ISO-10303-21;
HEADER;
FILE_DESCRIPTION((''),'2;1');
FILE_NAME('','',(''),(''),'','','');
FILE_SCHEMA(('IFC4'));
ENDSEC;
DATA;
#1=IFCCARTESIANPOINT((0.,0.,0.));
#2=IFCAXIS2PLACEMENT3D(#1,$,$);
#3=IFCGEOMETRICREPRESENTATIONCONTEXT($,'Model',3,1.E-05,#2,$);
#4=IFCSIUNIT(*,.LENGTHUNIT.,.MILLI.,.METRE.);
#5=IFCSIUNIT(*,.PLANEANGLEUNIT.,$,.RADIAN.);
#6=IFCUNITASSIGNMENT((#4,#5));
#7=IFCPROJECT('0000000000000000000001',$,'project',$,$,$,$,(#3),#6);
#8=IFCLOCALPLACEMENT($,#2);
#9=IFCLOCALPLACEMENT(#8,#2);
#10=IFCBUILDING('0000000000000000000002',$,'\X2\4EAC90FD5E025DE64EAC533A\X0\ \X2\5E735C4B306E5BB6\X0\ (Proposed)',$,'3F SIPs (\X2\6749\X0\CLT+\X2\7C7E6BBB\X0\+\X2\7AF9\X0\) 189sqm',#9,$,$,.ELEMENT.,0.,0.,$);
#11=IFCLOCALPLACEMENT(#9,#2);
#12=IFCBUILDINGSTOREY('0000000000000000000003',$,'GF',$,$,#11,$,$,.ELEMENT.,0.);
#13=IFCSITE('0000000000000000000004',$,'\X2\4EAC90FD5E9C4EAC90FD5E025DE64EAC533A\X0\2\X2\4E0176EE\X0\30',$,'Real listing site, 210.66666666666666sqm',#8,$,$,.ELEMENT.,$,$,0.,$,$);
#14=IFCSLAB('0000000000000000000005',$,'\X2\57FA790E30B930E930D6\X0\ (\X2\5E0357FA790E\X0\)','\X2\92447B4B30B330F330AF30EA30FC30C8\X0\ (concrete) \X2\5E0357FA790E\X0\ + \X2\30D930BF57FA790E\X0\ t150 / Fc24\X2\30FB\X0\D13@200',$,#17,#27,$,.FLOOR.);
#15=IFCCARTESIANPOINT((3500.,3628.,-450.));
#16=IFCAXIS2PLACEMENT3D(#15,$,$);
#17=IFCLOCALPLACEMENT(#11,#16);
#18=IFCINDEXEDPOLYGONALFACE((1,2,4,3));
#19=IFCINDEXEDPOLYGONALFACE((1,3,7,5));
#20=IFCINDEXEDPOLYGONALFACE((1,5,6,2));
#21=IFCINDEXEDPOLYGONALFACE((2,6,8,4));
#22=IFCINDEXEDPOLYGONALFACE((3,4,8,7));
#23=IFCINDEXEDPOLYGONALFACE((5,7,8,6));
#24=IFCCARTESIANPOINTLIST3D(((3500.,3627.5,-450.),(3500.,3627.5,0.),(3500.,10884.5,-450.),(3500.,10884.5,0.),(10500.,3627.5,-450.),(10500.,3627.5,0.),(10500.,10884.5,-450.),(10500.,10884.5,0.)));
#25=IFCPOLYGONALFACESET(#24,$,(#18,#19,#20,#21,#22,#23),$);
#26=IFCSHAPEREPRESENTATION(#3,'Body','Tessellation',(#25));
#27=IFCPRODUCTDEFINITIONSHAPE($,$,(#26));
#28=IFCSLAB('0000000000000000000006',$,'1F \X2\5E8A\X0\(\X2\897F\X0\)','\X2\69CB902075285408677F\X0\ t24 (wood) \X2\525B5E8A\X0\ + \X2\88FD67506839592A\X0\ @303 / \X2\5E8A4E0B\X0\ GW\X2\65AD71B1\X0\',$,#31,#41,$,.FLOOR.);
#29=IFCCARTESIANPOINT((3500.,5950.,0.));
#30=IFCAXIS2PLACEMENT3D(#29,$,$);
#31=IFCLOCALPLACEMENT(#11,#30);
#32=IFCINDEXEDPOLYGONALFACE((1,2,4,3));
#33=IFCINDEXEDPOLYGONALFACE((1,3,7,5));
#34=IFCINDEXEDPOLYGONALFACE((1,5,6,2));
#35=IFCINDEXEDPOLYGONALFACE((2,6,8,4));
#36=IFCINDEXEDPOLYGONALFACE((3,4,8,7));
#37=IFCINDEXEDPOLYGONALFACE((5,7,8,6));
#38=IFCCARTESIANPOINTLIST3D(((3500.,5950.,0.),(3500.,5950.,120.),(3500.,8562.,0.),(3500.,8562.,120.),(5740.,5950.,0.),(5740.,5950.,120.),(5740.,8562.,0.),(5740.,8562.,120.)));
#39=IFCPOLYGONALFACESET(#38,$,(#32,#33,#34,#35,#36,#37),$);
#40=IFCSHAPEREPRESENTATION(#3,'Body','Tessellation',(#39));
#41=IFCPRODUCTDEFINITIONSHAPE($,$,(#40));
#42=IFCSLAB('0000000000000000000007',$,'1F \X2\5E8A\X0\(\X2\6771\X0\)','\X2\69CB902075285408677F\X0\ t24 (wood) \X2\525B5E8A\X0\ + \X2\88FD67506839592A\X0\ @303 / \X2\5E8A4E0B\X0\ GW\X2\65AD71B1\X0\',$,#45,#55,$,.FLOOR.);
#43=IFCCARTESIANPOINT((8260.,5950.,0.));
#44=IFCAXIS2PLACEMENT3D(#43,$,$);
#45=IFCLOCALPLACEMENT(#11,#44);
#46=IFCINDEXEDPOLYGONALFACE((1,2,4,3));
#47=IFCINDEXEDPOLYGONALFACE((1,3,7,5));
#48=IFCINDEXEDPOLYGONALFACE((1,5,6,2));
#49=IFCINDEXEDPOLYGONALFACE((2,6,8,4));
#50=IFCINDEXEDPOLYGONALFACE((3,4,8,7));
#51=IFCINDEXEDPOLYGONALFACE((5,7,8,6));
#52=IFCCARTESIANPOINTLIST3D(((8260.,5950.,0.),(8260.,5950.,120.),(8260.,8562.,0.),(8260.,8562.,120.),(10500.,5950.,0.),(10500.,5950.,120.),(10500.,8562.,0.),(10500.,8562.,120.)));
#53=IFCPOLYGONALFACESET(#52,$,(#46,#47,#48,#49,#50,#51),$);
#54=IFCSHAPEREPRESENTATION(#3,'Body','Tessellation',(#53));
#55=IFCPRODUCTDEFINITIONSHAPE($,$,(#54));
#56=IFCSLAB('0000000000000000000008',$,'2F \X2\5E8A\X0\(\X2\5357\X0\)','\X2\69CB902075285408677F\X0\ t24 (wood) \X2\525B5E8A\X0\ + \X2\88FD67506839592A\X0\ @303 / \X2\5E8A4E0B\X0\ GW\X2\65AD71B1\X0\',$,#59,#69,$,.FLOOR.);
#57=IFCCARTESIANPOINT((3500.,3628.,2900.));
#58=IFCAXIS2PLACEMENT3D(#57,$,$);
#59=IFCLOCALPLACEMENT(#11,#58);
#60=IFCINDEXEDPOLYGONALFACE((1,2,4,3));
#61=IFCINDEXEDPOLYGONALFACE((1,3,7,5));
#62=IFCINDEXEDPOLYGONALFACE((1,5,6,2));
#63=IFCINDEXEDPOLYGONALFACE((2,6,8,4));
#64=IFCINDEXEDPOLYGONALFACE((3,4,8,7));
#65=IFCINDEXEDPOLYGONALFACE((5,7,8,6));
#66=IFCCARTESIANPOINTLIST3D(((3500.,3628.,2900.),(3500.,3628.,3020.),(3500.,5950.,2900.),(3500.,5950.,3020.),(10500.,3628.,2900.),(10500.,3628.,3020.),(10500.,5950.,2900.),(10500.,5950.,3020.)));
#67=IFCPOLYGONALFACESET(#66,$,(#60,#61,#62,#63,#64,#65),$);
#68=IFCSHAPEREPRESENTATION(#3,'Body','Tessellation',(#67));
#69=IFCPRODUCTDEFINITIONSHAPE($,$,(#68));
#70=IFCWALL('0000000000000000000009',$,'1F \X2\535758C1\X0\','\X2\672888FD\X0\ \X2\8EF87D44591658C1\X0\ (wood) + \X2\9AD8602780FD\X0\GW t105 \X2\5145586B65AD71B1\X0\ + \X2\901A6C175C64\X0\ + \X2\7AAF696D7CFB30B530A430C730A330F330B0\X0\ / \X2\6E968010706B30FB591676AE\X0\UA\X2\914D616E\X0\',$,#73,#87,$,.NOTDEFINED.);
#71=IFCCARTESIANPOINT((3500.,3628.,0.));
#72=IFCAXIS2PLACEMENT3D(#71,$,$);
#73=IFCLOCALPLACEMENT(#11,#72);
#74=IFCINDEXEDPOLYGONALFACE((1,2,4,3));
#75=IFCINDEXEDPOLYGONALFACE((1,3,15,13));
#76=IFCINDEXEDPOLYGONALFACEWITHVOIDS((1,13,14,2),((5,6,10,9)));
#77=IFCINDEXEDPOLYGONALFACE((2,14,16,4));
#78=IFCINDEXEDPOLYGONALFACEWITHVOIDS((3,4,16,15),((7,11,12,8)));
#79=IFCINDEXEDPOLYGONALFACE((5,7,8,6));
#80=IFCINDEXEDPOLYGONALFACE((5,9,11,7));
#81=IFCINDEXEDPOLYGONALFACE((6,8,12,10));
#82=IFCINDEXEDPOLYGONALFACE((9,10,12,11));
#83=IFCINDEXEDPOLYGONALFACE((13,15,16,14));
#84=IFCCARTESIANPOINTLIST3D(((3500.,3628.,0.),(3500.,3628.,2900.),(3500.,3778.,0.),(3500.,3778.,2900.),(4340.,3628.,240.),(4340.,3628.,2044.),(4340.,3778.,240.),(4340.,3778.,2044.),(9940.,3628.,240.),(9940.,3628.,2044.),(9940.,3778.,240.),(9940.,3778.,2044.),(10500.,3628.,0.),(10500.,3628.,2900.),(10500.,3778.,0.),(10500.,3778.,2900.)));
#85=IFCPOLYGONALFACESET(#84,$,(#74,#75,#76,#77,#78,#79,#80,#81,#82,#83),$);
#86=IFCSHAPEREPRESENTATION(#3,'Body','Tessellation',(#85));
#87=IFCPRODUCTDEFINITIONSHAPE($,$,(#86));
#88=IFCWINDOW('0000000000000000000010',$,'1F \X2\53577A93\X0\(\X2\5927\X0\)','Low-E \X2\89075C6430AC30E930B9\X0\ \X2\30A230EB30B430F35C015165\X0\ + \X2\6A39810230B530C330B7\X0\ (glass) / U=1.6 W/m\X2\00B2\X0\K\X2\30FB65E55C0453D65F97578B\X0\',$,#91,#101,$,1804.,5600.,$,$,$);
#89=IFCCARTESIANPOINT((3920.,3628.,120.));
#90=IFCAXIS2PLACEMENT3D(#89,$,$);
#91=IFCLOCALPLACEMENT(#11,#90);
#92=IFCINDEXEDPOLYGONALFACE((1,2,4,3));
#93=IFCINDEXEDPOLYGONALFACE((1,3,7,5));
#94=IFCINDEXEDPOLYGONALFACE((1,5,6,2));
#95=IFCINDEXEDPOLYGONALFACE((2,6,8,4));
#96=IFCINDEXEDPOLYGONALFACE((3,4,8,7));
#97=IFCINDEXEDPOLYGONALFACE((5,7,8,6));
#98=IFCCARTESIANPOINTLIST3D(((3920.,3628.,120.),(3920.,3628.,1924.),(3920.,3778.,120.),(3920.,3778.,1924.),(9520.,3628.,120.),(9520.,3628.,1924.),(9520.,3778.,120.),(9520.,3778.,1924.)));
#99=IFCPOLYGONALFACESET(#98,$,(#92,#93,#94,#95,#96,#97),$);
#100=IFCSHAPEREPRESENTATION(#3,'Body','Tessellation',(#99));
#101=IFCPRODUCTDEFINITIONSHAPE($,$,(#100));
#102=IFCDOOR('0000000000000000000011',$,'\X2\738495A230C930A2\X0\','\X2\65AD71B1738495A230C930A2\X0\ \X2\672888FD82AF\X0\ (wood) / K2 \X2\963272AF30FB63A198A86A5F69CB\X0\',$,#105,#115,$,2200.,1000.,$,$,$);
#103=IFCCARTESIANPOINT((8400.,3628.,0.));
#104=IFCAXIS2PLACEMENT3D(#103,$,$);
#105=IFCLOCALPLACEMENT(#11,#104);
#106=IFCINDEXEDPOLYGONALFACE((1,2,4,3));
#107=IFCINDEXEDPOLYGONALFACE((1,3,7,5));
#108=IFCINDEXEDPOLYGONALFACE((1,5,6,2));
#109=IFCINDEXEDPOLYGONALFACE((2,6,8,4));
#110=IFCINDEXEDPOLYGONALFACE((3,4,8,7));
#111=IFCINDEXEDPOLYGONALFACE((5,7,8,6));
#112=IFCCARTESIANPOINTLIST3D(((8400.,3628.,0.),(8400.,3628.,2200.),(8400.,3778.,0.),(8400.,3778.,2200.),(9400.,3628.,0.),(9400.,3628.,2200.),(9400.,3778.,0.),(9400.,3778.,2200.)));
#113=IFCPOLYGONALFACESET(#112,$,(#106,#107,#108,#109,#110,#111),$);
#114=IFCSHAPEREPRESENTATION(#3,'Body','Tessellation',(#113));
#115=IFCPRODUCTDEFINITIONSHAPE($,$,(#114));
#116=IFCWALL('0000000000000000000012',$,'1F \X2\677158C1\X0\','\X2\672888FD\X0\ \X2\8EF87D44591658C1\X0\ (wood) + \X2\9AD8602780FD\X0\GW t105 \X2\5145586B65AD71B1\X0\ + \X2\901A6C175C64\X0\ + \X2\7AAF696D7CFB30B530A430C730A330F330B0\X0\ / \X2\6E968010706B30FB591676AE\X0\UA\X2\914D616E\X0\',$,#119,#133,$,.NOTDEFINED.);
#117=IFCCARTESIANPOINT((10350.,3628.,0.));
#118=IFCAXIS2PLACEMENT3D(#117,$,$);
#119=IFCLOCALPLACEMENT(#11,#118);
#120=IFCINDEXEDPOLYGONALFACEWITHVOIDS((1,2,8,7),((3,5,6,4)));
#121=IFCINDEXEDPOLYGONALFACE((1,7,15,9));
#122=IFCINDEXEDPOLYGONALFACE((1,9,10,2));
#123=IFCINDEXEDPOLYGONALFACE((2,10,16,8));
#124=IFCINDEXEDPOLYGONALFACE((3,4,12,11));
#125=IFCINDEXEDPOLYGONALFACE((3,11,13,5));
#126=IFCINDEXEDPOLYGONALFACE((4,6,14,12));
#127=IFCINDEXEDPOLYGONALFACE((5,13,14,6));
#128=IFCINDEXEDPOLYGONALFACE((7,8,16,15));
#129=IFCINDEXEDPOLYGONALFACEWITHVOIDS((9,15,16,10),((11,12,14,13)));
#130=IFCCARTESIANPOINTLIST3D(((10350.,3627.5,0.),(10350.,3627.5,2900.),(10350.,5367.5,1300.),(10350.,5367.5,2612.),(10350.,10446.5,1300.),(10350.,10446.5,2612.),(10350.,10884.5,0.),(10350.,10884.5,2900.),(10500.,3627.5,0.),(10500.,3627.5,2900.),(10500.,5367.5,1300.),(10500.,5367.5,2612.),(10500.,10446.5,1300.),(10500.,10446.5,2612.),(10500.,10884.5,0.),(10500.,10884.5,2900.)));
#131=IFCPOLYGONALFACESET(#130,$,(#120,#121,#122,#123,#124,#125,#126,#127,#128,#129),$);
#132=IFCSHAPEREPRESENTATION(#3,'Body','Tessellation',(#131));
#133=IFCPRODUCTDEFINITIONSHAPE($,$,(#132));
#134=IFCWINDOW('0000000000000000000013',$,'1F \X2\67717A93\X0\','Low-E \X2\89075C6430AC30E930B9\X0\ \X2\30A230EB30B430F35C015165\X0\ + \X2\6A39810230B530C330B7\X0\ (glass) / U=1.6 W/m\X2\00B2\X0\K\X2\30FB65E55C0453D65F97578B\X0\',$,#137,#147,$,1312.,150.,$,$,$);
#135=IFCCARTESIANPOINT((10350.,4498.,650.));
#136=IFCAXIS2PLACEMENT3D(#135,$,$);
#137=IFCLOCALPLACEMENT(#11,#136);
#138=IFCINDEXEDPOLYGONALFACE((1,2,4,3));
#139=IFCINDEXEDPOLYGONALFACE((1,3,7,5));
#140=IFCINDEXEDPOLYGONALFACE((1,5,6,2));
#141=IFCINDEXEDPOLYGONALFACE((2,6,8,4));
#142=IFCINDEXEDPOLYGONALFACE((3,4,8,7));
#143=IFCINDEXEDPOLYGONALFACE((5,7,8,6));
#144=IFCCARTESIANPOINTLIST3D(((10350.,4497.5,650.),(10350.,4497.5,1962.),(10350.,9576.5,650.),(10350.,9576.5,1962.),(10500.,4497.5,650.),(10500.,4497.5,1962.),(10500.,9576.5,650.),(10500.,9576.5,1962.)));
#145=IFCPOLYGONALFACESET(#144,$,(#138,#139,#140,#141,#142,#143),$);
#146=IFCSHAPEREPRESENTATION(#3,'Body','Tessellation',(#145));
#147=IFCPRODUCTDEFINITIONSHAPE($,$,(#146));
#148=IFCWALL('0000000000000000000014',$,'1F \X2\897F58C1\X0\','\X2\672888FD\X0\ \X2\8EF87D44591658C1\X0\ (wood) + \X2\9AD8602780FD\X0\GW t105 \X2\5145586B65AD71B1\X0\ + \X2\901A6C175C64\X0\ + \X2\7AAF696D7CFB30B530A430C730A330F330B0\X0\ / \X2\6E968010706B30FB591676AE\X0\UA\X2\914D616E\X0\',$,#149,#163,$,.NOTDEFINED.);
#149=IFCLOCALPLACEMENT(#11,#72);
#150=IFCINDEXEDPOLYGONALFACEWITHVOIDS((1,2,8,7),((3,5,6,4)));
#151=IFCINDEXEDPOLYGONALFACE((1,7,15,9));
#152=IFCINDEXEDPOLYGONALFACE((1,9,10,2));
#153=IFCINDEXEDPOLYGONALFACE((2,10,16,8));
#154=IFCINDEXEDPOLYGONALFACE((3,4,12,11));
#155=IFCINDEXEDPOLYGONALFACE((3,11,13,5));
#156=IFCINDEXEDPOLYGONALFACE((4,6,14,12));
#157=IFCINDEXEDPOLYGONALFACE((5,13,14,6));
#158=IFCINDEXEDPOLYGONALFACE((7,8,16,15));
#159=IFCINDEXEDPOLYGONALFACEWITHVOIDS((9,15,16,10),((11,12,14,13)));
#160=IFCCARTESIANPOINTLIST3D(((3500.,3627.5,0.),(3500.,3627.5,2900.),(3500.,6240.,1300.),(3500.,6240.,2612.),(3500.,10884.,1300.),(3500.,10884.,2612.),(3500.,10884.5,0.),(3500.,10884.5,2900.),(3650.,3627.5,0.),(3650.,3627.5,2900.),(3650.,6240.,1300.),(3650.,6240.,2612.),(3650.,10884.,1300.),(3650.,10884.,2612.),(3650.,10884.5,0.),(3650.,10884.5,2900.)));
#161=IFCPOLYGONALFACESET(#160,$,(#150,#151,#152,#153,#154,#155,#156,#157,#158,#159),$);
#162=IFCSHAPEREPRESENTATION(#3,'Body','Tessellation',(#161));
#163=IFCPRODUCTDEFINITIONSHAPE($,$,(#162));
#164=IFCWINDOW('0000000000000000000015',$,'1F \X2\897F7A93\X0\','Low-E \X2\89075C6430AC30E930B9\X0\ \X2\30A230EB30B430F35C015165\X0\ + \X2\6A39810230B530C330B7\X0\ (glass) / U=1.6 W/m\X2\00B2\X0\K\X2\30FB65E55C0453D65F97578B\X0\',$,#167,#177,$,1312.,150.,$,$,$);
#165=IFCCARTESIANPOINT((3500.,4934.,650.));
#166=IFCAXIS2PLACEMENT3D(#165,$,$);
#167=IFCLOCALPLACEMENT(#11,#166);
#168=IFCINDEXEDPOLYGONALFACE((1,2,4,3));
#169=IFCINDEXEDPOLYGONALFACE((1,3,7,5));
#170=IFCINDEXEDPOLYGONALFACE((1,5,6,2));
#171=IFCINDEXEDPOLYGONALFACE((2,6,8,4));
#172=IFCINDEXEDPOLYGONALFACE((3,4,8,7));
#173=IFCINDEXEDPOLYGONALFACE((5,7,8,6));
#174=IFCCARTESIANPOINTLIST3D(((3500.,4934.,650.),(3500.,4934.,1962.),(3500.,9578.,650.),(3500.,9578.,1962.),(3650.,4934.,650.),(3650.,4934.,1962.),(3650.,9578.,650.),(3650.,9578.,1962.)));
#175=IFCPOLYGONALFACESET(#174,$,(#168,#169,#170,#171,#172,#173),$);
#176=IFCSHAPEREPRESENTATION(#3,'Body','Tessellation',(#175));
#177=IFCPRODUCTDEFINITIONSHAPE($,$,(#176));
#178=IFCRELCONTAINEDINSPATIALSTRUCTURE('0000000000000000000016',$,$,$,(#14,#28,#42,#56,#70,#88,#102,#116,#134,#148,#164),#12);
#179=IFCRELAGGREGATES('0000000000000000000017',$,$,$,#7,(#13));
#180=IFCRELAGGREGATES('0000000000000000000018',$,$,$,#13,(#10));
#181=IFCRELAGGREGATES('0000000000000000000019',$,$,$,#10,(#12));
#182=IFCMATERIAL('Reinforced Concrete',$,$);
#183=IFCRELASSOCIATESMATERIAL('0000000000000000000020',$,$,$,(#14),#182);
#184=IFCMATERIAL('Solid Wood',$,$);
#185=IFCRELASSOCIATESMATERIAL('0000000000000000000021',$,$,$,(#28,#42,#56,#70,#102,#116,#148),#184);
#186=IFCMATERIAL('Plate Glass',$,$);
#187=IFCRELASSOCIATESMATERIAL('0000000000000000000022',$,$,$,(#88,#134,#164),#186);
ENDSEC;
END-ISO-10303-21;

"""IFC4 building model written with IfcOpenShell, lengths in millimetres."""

from ifc_helpers import new_model, si_unit, frame, frame_2d, origin, place, context, project, spatial, rectangle, extrude, material, element, fill, save


model = new_model("IFC4")

# Units and contexts
model_context = context("Model", 3, precision=1e-05, world=origin())
ifc_project = project(units=[si_unit("LENGTHUNIT", "METRE", prefix="MILLI"), si_unit("PLANEANGLEUNIT", "RADIAN")], contexts=[model_context])

# Site, building, storey
site_placement = place(None, origin())
site = spatial("IfcSite", under=ifc_project, at=site_placement, Name="京都府京都市左京区2丁目30", ObjectType="Real listing site, 210.66666666666666sqm", CompositionType="ELEMENT", RefElevation=0.0)
building_placement = place(site_placement, origin())
building = spatial("IfcBuilding", under=site, at=building_placement, Name="京都市左京区 平屋の家 (Proposed)", ObjectType="3F SIPs (杉CLT+籾殻+竹) 189sqm", CompositionType="ELEMENT", ElevationOfRefHeight=0.0, ElevationOfTerrain=0.0)
storey_placement = place(building_placement, origin())
storey = spatial("IfcBuildingStorey", under=building, at=storey_placement, Name="GF", CompositionType="ELEMENT", Elevation=0.0)

# Slabs
ifc_material_1 = material(Name="Reinforced Concrete")
slab_1_placement = place(storey_placement, frame((3500.0, 3628.0, -450.0)))
element("IfcSlab", 1, at=slab_1_placement, inside=storey, material=ifc_material_1, Name="基礎スラブ (布基礎)", Description="鉄筋コンクリート (concrete) 布基礎 + ベタ基礎 t150 / Fc24・D13@200", PredefinedType="FLOOR", context=model_context, shape_type="SweptSolid", body=[
    extrude(rectangle(XDim=7000.0, YDim=7257.0, at=frame_2d((3500.0, 3628.0))), frame((3500.0, 3628.0, -450.0)), (0.0, 0.0, 1.0), 450.0),
])
ifc_material_2 = material(Name="Solid Wood")
slab_2_placement = place(storey_placement, frame((3500.0, 5950.0, 0.0)))
element("IfcSlab", 2, at=slab_2_placement, inside=storey, material=ifc_material_2, Name="1F 床(西)", Description="構造用合板 t24 (wood) 剛床 + 製材根太 @303 / 床下 GW断熱", PredefinedType="FLOOR", context=model_context, shape_type="SweptSolid", body=[
    extrude(rectangle(XDim=2240.0, YDim=2612.0, at=frame_2d((1120.0, 1306.0))), frame((3500.0, 5950.0, 0.0)), (0.0, 0.0, 1.0), 120.0),
])
slab_3_placement = place(storey_placement, frame((8260.0, 5950.0, 0.0)))
element("IfcSlab", 3, at=slab_3_placement, inside=storey, material=ifc_material_2, Name="1F 床(東)", Description="構造用合板 t24 (wood) 剛床 + 製材根太 @303 / 床下 GW断熱", PredefinedType="FLOOR", context=model_context, shape_type="SweptSolid", body=[
    extrude(rectangle(XDim=2240.0, YDim=2612.0, at=frame_2d((1120.0, 1306.0))), frame((8260.0, 5950.0, 0.0)), (0.0, 0.0, 1.0), 120.0),
])
slab_4_placement = place(storey_placement, frame((3500.0, 3628.0, 2900.0)))
element("IfcSlab", 4, at=slab_4_placement, inside=storey, material=ifc_material_2, Name="2F 床(南)", Description="構造用合板 t24 (wood) 剛床 + 製材根太 @303 / 床下 GW断熱", PredefinedType="FLOOR", context=model_context, shape_type="SweptSolid", body=[
    extrude(rectangle(XDim=7000.0, YDim=2322.0, at=frame_2d((3500.0, 1161.0))), frame((3500.0, 3628.0, 2900.0)), (0.0, 0.0, 1.0), 120.0),
])

# Wall, openings, window, door
wall_1_placement = place(storey_placement, frame((3500.0, 3628.0, 0.0)))
wall_1 = element("IfcWall", 5, at=wall_1_placement, inside=storey, material=ifc_material_2, Name="1F 南壁", Description="木製 軸組外壁 (wood) + 高性能GW t105 充填断熱 + 通気層 + 窯業系サイディング / 準耐火・外皮UA配慮", PredefinedType="NOTDEFINED", context=model_context, shape_type="SweptSolid", body=[
    extrude(rectangle(XDim=7000.0, YDim=150.0, at=frame_2d((3500.0, 75.0))), frame((3500.0, 3628.0, 0.0)), (0.0, 0.0, 1.0), 2900.0),
])
opening_1_placement = place(storey_placement, frame((3920.0, 3628.0, 120.0)))
opening_1 = element("IfcOpeningElement", 6, at=opening_1_placement, cuts=wall_1, PredefinedType="NOTDEFINED", context=model_context, shape_type="SweptSolid", body=[
    extrude(rectangle(XDim=5600.0, YDim=150.0, at=frame_2d((2800.0, 75.0))), frame((3920.0, 3628.0, 120.0)), (0.0, 0.0, 1.0), 1804.0),
])
opening_2_placement = place(storey_placement, frame((8400.0, 3628.0, 0.0)))
opening_2 = element("IfcOpeningElement", 7, at=opening_2_placement, cuts=wall_1, PredefinedType="NOTDEFINED", context=model_context, shape_type="SweptSolid", body=[
    extrude(rectangle(XDim=1000.0, YDim=150.0, at=frame_2d((500.0, 75.0))), frame((8400.0, 3628.0, 0.0)), (0.0, 0.0, 1.0), 2200.0),
])
ifc_material_3 = material(Name="Plate Glass")
window_1_placement = place(storey_placement, frame((3920.0, 3628.0, 120.0)))
window_1 = element("IfcWindow", 8, at=window_1_placement, inside=storey, material=ifc_material_3, Name="1F 南窓(大)", Description="Low-E 複層ガラス アルゴン封入 + 樹脂サッシ (glass) / U=1.6 W/m²K・日射取得型", OverallHeight=1804.0, OverallWidth=5600.0, context=model_context, shape_type="SweptSolid", body=[
    extrude(rectangle(XDim=5600.0, YDim=150.0, at=frame_2d((2800.0, 75.0))), frame((3920.0, 3628.0, 120.0)), (0.0, 0.0, 1.0), 1804.0),
])
fill(opening_1, window_1)
door_placement = place(storey_placement, frame((8400.0, 3628.0, 0.0)))
door = element("IfcDoor", 9, at=door_placement, inside=storey, material=ifc_material_2, Name="玄関ドア", Description="断熱玄関ドア 木製芯 (wood) / K2 防犯・採風機構", OverallHeight=2200.0, OverallWidth=1000.0, context=model_context, shape_type="SweptSolid", body=[
    extrude(rectangle(XDim=1000.0, YDim=150.0, at=frame_2d((500.0, 75.0))), frame((8400.0, 3628.0, 0.0)), (0.0, 0.0, 1.0), 2200.0),
])
fill(opening_2, door)

# Walls, openings, windows
wall_2_placement = place(storey_placement, frame((10350.0, 3628.0, 0.0)))
wall_2 = element("IfcWall", 10, at=wall_2_placement, inside=storey, material=ifc_material_2, Name="1F 東壁", Description="木製 軸組外壁 (wood) + 高性能GW t105 充填断熱 + 通気層 + 窯業系サイディング / 準耐火・外皮UA配慮", PredefinedType="NOTDEFINED", context=model_context, shape_type="SweptSolid", body=[
    extrude(rectangle(XDim=150.0, YDim=7257.0, at=frame_2d((75.0, 3628.0))), frame((10350.0, 3628.0, 0.0)), (0.0, 0.0, 1.0), 2900.0),
])
opening_3_placement = place(storey_placement, frame((10350.0, 4498.0, 650.0)))
opening_3 = element("IfcOpeningElement", 11, at=opening_3_placement, cuts=wall_2, PredefinedType="NOTDEFINED", context=model_context, shape_type="SweptSolid", body=[
    extrude(rectangle(XDim=150.0, YDim=5079.0, at=frame_2d((75.0, 2539.0))), frame((10350.0, 4498.0, 650.0)), (0.0, 0.0, 1.0), 1312.0),
])
window_2_placement = place(storey_placement, frame((10350.0, 4498.0, 650.0)))
window_2 = element("IfcWindow", 12, at=window_2_placement, inside=storey, material=ifc_material_3, Name="1F 東窓", Description="Low-E 複層ガラス アルゴン封入 + 樹脂サッシ (glass) / U=1.6 W/m²K・日射取得型", OverallHeight=1312.0, OverallWidth=150.0, context=model_context, shape_type="SweptSolid", body=[
    extrude(rectangle(XDim=150.0, YDim=5079.0, at=frame_2d((75.0, 2539.0))), frame((10350.0, 4498.0, 650.0)), (0.0, 0.0, 1.0), 1312.0),
])
fill(opening_3, window_2)
wall_3_placement = place(storey_placement, frame((3500.0, 3628.0, 0.0)))
wall_3 = element("IfcWall", 13, at=wall_3_placement, inside=storey, material=ifc_material_2, Name="1F 西壁", Description="木製 軸組外壁 (wood) + 高性能GW t105 充填断熱 + 通気層 + 窯業系サイディング / 準耐火・外皮UA配慮", PredefinedType="NOTDEFINED", context=model_context, shape_type="SweptSolid", body=[
    extrude(rectangle(XDim=150.0, YDim=7257.0, at=frame_2d((75.0, 3628.0))), frame((3500.0, 3628.0, 0.0)), (0.0, 0.0, 1.0), 2900.0),
])
opening_4_placement = place(storey_placement, frame((3500.0, 4934.0, 650.0)))
opening_4 = element("IfcOpeningElement", 14, at=opening_4_placement, cuts=wall_3, PredefinedType="NOTDEFINED", context=model_context, shape_type="SweptSolid", body=[
    extrude(rectangle(XDim=150.0, YDim=4644.0, at=frame_2d((75.0, 2322.0))), frame((3500.0, 4934.0, 650.0)), (0.0, 0.0, 1.0), 1312.0),
])
window_3_placement = place(storey_placement, frame((3500.0, 4934.0, 650.0)))
window_3 = element("IfcWindow", 15, at=window_3_placement, inside=storey, material=ifc_material_3, Name="1F 西窓", Description="Low-E 複層ガラス アルゴン封入 + 樹脂サッシ (glass) / U=1.6 W/m²K・日射取得型", OverallHeight=1312.0, OverallWidth=150.0, context=model_context, shape_type="SweptSolid", body=[
    extrude(rectangle(XDim=150.0, YDim=4644.0, at=frame_2d((75.0, 2322.0))), frame((3500.0, 4934.0, 650.0)), (0.0, 0.0, 1.0), 1312.0),
])
fill(opening_4, window_3)

save(model, "model.ifc")
